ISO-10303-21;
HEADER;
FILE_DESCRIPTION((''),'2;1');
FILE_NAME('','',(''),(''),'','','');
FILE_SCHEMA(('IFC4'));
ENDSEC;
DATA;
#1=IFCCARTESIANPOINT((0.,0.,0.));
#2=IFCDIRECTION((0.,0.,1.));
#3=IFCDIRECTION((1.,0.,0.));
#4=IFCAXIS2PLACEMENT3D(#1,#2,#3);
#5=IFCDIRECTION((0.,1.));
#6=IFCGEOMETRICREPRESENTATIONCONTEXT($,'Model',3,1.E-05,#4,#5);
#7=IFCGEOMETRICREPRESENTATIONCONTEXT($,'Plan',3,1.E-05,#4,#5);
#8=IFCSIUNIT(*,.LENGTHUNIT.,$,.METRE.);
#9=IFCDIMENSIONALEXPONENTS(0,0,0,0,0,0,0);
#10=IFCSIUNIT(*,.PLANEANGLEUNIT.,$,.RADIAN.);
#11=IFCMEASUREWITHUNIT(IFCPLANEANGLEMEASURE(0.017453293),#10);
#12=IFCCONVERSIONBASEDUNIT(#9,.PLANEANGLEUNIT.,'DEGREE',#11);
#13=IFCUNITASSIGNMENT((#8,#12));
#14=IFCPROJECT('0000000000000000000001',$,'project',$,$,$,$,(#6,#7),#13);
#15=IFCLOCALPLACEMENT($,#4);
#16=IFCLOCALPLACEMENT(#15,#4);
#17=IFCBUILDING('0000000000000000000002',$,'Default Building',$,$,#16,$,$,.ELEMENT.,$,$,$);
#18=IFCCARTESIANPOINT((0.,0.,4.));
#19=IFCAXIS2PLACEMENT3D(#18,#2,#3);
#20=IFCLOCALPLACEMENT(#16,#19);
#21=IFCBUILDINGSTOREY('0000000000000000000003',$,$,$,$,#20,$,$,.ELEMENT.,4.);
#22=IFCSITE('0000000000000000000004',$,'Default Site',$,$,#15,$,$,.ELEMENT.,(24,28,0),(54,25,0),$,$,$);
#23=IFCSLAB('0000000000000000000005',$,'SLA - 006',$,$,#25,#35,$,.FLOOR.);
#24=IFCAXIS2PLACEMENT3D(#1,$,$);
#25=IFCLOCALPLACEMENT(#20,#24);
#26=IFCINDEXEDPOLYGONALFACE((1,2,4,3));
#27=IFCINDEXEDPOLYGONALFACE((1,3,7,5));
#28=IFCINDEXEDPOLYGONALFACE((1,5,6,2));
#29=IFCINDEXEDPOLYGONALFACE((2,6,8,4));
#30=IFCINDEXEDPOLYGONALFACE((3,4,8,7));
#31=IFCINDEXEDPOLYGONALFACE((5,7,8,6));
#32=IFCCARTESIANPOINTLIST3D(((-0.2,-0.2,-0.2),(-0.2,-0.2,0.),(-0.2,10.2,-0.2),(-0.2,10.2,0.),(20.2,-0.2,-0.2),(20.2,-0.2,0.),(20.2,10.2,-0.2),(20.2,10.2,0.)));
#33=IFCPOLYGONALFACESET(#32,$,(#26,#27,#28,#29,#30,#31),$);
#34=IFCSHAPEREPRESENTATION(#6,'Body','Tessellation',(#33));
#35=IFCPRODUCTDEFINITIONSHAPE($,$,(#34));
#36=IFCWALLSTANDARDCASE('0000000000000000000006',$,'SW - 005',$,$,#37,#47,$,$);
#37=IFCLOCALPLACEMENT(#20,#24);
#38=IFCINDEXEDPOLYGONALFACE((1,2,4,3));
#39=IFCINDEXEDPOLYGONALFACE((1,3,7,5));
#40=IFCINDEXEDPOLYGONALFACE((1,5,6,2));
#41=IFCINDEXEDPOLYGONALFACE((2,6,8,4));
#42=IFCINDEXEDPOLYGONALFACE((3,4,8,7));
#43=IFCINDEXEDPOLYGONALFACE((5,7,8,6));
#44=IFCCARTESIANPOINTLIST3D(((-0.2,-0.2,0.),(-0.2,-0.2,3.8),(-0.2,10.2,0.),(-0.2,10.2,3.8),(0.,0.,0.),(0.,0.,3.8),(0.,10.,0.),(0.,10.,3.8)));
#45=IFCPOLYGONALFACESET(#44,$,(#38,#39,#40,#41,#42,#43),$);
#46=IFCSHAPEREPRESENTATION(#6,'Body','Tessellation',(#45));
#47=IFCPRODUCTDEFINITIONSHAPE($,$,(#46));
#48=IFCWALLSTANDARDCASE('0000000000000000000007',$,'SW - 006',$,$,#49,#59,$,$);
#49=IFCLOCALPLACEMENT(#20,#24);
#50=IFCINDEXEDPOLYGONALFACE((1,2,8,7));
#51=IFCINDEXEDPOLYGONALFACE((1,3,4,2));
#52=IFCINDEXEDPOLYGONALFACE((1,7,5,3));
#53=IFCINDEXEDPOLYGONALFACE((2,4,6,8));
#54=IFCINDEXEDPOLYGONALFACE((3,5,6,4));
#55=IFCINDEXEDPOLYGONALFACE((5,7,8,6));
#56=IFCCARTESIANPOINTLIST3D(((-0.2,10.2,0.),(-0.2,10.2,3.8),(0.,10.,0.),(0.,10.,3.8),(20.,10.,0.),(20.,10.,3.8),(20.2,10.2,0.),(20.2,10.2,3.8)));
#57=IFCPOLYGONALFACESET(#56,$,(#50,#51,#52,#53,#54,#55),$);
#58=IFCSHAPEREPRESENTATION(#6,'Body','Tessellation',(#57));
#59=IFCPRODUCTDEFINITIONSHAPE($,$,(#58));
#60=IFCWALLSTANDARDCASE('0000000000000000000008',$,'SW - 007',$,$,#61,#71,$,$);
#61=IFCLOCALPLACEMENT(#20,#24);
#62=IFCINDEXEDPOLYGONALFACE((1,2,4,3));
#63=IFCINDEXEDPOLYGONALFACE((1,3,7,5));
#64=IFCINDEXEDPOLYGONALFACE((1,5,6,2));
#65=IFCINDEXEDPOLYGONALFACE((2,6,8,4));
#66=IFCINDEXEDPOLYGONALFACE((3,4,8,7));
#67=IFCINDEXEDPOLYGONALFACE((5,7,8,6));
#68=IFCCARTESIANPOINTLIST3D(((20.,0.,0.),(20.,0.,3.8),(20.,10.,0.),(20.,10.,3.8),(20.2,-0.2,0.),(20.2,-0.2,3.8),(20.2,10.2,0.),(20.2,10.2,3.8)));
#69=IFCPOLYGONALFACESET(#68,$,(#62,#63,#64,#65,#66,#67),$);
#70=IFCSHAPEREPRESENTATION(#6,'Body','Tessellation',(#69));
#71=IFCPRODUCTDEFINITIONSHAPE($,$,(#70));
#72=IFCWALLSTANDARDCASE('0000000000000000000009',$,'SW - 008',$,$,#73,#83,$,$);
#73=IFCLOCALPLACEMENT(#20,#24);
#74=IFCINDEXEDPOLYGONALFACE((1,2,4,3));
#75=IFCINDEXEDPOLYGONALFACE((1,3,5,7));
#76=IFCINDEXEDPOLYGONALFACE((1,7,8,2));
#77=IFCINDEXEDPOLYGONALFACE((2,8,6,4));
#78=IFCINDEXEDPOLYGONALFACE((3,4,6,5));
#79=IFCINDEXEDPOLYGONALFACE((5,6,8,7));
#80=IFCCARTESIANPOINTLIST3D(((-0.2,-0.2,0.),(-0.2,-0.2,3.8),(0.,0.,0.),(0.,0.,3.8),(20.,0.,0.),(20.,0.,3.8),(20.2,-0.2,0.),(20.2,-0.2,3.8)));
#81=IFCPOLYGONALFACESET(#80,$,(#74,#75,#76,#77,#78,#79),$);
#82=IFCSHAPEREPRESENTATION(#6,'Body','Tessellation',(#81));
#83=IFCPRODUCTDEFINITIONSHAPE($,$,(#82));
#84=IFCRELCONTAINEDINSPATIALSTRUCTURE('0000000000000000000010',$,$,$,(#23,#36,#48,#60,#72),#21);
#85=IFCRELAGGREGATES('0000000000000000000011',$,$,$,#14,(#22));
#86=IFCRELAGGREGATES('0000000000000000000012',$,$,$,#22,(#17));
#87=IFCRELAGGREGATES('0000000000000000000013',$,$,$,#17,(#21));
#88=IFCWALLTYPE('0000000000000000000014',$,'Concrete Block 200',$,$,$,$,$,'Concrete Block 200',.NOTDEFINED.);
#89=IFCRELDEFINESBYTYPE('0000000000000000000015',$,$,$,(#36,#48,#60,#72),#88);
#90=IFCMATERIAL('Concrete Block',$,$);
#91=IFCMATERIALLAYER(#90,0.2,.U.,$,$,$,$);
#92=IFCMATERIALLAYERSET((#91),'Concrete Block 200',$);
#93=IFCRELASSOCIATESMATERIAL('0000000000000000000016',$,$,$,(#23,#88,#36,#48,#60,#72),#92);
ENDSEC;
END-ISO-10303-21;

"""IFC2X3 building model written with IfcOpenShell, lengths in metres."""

from ifc_helpers import new_model, entity, si_unit, converted_unit, direction, frame, origin_with_axes, place, context, project, spatial, polyline, outline, extrude, material, layer, layer_set, layer_usage, type_object, element, save


model = new_model("IFC2X3")

# Units and contexts
model_context = context("Model", 3, precision=1e-05, world=origin_with_axes(), true_north=direction((0.0, 1.0)))
plan_context = context("Plan", 3, precision=1e-05, world=origin_with_axes(), true_north=direction((0.0, 1.0)))
ifc_project = project(units=[si_unit("LENGTHUNIT", "METRE"), converted_unit("PLANEANGLEUNIT", "DEGREE", entity("IfcPlaneAngleMeasure", 0.017453293), si_unit("PLANEANGLEUNIT", "RADIAN"), dimensions=[0, 0, 0, 0, 0, 0, 0])], contexts=[model_context, plan_context])

# Site, building, storey
site_placement = place(None, origin_with_axes())
site = spatial("IfcSite", under=ifc_project, at=site_placement, Name="Default Site", CompositionType="ELEMENT", RefLatitude=(24, 28, 0), RefLongitude=(54, 25, 0))
building_placement = place(site_placement, origin_with_axes())
building = spatial("IfcBuilding", under=site, at=building_placement, Name="Default Building", CompositionType="ELEMENT")
storey_placement = place(building_placement, frame((0.0, 0.0, 4.0), z_axis=(0.0, 0.0, 1.0), x_axis=(1.0, 0.0, 0.0)))
storey = spatial("IfcBuildingStorey", under=building, at=storey_placement, CompositionType="ELEMENT", Elevation=4.0)

# Slab
ifc_material = material(Name="Concrete Block")
ifc_layer = layer(ifc_material, 0.2, ventilated="UNKNOWN")
ifc_layer_set = layer_set([ifc_layer], Name="Concrete Block 200")
ifc_layer_usage_1 = layer_usage(ifc_layer_set, "AXIS3", "NEGATIVE", 0.2)
slab_placement = place(storey_placement, frame((-0.2, 10.2, -0.2), z_axis=(0.0, 0.0, 1.0), x_axis=(1.0, 0.0, 0.0)))
element("IfcSlab", 1, at=slab_placement, inside=storey, material=ifc_layer_usage_1, Name="SLA - 006", PredefinedType="FLOOR", context=model_context, shape_type="SweptSolid", body=[
    extrude(outline(polyline([(0.0, 0.0), (20.4, 0.0), (20.4, -10.4), (0.0, -10.4), (0.0, 0.0)])), origin_with_axes(), (0.0, 0.0, 1.0), 0.2),
])

# Walls
ifc_layer_usage_2 = layer_usage(ifc_layer_set, "AXIS2", "POSITIVE", 0.0)
wall_type = type_object("IfcWallType", Name="Concrete Block 200", ElementType="Concrete Block 200", PredefinedType="NOTDEFINED", material=ifc_layer_set)
wall_1_placement = place(storey_placement, frame((0.0, 0.0, 0.0), z_axis=(0.0, 0.0, 1.0), x_axis=(0.0, 1.0, 0.0)))
element("IfcWallStandardCase", 2, at=wall_1_placement, inside=storey, type_object=wall_type, material=ifc_layer_usage_2, Name="SW - 005", context=model_context, shape_type="SweptSolid", body=[
    extrude(outline(polyline([(0.0, 0.0), (10.0, 0.0), (10.2, 0.2), (-0.2, 0.2), (0.0, 0.0)])), origin_with_axes(), (0.0, 0.0, 1.0), 3.8),
])
ifc_layer_usage_3 = layer_usage(ifc_layer_set, "AXIS2", "POSITIVE", 0.0)
wall_2_placement = place(storey_placement, frame((0.0, 10.0, 0.0), z_axis=(0.0, 0.0, 1.0), x_axis=(1.0, 0.0, 0.0)))
element("IfcWallStandardCase", 3, at=wall_2_placement, inside=storey, type_object=wall_type, material=ifc_layer_usage_3, Name="SW - 006", context=model_context, shape_type="SweptSolid", body=[
    extrude(outline(polyline([(0.0, 0.0), (20.0, 0.0), (20.2, 0.2), (-0.2, 0.2), (0.0, 0.0)])), origin_with_axes(), (0.0, 0.0, 1.0), 3.8),
])
ifc_layer_usage_4 = layer_usage(ifc_layer_set, "AXIS2", "POSITIVE", 0.0)
wall_3_placement = place(storey_placement, frame((20.0, 10.0, 0.0), z_axis=(0.0, 0.0, 1.0), x_axis=(0.0, -1.0, 0.0)))
element("IfcWallStandardCase", 4, at=wall_3_placement, inside=storey, type_object=wall_type, material=ifc_layer_usage_4, Name="SW - 007", context=model_context, shape_type="SweptSolid", body=[
    extrude(outline(polyline([(0.0, 0.0), (10.0, 0.0), (10.2, 0.2), (-0.2, 0.2), (0.0, 0.0)])), origin_with_axes(), (0.0, 0.0, 1.0), 3.8),
])
ifc_layer_usage_5 = layer_usage(ifc_layer_set, "AXIS2", "POSITIVE", 0.0)
wall_4_placement = place(storey_placement, frame((20.0, 0.0, 0.0), z_axis=(0.0, 0.0, 1.0), x_axis=(-1.0, 0.0, 0.0)))
element("IfcWallStandardCase", 5, at=wall_4_placement, inside=storey, type_object=wall_type, material=ifc_layer_usage_5, Name="SW - 008", context=model_context, shape_type="SweptSolid", body=[
    extrude(outline(polyline([(0.0, 0.0), (20.0, 0.0), (20.2, 0.2), (-0.2, 0.2), (0.0, 0.0)])), origin_with_axes(), (0.0, 0.0, 1.0), 3.8),
])

save(model, "model.ifc")
